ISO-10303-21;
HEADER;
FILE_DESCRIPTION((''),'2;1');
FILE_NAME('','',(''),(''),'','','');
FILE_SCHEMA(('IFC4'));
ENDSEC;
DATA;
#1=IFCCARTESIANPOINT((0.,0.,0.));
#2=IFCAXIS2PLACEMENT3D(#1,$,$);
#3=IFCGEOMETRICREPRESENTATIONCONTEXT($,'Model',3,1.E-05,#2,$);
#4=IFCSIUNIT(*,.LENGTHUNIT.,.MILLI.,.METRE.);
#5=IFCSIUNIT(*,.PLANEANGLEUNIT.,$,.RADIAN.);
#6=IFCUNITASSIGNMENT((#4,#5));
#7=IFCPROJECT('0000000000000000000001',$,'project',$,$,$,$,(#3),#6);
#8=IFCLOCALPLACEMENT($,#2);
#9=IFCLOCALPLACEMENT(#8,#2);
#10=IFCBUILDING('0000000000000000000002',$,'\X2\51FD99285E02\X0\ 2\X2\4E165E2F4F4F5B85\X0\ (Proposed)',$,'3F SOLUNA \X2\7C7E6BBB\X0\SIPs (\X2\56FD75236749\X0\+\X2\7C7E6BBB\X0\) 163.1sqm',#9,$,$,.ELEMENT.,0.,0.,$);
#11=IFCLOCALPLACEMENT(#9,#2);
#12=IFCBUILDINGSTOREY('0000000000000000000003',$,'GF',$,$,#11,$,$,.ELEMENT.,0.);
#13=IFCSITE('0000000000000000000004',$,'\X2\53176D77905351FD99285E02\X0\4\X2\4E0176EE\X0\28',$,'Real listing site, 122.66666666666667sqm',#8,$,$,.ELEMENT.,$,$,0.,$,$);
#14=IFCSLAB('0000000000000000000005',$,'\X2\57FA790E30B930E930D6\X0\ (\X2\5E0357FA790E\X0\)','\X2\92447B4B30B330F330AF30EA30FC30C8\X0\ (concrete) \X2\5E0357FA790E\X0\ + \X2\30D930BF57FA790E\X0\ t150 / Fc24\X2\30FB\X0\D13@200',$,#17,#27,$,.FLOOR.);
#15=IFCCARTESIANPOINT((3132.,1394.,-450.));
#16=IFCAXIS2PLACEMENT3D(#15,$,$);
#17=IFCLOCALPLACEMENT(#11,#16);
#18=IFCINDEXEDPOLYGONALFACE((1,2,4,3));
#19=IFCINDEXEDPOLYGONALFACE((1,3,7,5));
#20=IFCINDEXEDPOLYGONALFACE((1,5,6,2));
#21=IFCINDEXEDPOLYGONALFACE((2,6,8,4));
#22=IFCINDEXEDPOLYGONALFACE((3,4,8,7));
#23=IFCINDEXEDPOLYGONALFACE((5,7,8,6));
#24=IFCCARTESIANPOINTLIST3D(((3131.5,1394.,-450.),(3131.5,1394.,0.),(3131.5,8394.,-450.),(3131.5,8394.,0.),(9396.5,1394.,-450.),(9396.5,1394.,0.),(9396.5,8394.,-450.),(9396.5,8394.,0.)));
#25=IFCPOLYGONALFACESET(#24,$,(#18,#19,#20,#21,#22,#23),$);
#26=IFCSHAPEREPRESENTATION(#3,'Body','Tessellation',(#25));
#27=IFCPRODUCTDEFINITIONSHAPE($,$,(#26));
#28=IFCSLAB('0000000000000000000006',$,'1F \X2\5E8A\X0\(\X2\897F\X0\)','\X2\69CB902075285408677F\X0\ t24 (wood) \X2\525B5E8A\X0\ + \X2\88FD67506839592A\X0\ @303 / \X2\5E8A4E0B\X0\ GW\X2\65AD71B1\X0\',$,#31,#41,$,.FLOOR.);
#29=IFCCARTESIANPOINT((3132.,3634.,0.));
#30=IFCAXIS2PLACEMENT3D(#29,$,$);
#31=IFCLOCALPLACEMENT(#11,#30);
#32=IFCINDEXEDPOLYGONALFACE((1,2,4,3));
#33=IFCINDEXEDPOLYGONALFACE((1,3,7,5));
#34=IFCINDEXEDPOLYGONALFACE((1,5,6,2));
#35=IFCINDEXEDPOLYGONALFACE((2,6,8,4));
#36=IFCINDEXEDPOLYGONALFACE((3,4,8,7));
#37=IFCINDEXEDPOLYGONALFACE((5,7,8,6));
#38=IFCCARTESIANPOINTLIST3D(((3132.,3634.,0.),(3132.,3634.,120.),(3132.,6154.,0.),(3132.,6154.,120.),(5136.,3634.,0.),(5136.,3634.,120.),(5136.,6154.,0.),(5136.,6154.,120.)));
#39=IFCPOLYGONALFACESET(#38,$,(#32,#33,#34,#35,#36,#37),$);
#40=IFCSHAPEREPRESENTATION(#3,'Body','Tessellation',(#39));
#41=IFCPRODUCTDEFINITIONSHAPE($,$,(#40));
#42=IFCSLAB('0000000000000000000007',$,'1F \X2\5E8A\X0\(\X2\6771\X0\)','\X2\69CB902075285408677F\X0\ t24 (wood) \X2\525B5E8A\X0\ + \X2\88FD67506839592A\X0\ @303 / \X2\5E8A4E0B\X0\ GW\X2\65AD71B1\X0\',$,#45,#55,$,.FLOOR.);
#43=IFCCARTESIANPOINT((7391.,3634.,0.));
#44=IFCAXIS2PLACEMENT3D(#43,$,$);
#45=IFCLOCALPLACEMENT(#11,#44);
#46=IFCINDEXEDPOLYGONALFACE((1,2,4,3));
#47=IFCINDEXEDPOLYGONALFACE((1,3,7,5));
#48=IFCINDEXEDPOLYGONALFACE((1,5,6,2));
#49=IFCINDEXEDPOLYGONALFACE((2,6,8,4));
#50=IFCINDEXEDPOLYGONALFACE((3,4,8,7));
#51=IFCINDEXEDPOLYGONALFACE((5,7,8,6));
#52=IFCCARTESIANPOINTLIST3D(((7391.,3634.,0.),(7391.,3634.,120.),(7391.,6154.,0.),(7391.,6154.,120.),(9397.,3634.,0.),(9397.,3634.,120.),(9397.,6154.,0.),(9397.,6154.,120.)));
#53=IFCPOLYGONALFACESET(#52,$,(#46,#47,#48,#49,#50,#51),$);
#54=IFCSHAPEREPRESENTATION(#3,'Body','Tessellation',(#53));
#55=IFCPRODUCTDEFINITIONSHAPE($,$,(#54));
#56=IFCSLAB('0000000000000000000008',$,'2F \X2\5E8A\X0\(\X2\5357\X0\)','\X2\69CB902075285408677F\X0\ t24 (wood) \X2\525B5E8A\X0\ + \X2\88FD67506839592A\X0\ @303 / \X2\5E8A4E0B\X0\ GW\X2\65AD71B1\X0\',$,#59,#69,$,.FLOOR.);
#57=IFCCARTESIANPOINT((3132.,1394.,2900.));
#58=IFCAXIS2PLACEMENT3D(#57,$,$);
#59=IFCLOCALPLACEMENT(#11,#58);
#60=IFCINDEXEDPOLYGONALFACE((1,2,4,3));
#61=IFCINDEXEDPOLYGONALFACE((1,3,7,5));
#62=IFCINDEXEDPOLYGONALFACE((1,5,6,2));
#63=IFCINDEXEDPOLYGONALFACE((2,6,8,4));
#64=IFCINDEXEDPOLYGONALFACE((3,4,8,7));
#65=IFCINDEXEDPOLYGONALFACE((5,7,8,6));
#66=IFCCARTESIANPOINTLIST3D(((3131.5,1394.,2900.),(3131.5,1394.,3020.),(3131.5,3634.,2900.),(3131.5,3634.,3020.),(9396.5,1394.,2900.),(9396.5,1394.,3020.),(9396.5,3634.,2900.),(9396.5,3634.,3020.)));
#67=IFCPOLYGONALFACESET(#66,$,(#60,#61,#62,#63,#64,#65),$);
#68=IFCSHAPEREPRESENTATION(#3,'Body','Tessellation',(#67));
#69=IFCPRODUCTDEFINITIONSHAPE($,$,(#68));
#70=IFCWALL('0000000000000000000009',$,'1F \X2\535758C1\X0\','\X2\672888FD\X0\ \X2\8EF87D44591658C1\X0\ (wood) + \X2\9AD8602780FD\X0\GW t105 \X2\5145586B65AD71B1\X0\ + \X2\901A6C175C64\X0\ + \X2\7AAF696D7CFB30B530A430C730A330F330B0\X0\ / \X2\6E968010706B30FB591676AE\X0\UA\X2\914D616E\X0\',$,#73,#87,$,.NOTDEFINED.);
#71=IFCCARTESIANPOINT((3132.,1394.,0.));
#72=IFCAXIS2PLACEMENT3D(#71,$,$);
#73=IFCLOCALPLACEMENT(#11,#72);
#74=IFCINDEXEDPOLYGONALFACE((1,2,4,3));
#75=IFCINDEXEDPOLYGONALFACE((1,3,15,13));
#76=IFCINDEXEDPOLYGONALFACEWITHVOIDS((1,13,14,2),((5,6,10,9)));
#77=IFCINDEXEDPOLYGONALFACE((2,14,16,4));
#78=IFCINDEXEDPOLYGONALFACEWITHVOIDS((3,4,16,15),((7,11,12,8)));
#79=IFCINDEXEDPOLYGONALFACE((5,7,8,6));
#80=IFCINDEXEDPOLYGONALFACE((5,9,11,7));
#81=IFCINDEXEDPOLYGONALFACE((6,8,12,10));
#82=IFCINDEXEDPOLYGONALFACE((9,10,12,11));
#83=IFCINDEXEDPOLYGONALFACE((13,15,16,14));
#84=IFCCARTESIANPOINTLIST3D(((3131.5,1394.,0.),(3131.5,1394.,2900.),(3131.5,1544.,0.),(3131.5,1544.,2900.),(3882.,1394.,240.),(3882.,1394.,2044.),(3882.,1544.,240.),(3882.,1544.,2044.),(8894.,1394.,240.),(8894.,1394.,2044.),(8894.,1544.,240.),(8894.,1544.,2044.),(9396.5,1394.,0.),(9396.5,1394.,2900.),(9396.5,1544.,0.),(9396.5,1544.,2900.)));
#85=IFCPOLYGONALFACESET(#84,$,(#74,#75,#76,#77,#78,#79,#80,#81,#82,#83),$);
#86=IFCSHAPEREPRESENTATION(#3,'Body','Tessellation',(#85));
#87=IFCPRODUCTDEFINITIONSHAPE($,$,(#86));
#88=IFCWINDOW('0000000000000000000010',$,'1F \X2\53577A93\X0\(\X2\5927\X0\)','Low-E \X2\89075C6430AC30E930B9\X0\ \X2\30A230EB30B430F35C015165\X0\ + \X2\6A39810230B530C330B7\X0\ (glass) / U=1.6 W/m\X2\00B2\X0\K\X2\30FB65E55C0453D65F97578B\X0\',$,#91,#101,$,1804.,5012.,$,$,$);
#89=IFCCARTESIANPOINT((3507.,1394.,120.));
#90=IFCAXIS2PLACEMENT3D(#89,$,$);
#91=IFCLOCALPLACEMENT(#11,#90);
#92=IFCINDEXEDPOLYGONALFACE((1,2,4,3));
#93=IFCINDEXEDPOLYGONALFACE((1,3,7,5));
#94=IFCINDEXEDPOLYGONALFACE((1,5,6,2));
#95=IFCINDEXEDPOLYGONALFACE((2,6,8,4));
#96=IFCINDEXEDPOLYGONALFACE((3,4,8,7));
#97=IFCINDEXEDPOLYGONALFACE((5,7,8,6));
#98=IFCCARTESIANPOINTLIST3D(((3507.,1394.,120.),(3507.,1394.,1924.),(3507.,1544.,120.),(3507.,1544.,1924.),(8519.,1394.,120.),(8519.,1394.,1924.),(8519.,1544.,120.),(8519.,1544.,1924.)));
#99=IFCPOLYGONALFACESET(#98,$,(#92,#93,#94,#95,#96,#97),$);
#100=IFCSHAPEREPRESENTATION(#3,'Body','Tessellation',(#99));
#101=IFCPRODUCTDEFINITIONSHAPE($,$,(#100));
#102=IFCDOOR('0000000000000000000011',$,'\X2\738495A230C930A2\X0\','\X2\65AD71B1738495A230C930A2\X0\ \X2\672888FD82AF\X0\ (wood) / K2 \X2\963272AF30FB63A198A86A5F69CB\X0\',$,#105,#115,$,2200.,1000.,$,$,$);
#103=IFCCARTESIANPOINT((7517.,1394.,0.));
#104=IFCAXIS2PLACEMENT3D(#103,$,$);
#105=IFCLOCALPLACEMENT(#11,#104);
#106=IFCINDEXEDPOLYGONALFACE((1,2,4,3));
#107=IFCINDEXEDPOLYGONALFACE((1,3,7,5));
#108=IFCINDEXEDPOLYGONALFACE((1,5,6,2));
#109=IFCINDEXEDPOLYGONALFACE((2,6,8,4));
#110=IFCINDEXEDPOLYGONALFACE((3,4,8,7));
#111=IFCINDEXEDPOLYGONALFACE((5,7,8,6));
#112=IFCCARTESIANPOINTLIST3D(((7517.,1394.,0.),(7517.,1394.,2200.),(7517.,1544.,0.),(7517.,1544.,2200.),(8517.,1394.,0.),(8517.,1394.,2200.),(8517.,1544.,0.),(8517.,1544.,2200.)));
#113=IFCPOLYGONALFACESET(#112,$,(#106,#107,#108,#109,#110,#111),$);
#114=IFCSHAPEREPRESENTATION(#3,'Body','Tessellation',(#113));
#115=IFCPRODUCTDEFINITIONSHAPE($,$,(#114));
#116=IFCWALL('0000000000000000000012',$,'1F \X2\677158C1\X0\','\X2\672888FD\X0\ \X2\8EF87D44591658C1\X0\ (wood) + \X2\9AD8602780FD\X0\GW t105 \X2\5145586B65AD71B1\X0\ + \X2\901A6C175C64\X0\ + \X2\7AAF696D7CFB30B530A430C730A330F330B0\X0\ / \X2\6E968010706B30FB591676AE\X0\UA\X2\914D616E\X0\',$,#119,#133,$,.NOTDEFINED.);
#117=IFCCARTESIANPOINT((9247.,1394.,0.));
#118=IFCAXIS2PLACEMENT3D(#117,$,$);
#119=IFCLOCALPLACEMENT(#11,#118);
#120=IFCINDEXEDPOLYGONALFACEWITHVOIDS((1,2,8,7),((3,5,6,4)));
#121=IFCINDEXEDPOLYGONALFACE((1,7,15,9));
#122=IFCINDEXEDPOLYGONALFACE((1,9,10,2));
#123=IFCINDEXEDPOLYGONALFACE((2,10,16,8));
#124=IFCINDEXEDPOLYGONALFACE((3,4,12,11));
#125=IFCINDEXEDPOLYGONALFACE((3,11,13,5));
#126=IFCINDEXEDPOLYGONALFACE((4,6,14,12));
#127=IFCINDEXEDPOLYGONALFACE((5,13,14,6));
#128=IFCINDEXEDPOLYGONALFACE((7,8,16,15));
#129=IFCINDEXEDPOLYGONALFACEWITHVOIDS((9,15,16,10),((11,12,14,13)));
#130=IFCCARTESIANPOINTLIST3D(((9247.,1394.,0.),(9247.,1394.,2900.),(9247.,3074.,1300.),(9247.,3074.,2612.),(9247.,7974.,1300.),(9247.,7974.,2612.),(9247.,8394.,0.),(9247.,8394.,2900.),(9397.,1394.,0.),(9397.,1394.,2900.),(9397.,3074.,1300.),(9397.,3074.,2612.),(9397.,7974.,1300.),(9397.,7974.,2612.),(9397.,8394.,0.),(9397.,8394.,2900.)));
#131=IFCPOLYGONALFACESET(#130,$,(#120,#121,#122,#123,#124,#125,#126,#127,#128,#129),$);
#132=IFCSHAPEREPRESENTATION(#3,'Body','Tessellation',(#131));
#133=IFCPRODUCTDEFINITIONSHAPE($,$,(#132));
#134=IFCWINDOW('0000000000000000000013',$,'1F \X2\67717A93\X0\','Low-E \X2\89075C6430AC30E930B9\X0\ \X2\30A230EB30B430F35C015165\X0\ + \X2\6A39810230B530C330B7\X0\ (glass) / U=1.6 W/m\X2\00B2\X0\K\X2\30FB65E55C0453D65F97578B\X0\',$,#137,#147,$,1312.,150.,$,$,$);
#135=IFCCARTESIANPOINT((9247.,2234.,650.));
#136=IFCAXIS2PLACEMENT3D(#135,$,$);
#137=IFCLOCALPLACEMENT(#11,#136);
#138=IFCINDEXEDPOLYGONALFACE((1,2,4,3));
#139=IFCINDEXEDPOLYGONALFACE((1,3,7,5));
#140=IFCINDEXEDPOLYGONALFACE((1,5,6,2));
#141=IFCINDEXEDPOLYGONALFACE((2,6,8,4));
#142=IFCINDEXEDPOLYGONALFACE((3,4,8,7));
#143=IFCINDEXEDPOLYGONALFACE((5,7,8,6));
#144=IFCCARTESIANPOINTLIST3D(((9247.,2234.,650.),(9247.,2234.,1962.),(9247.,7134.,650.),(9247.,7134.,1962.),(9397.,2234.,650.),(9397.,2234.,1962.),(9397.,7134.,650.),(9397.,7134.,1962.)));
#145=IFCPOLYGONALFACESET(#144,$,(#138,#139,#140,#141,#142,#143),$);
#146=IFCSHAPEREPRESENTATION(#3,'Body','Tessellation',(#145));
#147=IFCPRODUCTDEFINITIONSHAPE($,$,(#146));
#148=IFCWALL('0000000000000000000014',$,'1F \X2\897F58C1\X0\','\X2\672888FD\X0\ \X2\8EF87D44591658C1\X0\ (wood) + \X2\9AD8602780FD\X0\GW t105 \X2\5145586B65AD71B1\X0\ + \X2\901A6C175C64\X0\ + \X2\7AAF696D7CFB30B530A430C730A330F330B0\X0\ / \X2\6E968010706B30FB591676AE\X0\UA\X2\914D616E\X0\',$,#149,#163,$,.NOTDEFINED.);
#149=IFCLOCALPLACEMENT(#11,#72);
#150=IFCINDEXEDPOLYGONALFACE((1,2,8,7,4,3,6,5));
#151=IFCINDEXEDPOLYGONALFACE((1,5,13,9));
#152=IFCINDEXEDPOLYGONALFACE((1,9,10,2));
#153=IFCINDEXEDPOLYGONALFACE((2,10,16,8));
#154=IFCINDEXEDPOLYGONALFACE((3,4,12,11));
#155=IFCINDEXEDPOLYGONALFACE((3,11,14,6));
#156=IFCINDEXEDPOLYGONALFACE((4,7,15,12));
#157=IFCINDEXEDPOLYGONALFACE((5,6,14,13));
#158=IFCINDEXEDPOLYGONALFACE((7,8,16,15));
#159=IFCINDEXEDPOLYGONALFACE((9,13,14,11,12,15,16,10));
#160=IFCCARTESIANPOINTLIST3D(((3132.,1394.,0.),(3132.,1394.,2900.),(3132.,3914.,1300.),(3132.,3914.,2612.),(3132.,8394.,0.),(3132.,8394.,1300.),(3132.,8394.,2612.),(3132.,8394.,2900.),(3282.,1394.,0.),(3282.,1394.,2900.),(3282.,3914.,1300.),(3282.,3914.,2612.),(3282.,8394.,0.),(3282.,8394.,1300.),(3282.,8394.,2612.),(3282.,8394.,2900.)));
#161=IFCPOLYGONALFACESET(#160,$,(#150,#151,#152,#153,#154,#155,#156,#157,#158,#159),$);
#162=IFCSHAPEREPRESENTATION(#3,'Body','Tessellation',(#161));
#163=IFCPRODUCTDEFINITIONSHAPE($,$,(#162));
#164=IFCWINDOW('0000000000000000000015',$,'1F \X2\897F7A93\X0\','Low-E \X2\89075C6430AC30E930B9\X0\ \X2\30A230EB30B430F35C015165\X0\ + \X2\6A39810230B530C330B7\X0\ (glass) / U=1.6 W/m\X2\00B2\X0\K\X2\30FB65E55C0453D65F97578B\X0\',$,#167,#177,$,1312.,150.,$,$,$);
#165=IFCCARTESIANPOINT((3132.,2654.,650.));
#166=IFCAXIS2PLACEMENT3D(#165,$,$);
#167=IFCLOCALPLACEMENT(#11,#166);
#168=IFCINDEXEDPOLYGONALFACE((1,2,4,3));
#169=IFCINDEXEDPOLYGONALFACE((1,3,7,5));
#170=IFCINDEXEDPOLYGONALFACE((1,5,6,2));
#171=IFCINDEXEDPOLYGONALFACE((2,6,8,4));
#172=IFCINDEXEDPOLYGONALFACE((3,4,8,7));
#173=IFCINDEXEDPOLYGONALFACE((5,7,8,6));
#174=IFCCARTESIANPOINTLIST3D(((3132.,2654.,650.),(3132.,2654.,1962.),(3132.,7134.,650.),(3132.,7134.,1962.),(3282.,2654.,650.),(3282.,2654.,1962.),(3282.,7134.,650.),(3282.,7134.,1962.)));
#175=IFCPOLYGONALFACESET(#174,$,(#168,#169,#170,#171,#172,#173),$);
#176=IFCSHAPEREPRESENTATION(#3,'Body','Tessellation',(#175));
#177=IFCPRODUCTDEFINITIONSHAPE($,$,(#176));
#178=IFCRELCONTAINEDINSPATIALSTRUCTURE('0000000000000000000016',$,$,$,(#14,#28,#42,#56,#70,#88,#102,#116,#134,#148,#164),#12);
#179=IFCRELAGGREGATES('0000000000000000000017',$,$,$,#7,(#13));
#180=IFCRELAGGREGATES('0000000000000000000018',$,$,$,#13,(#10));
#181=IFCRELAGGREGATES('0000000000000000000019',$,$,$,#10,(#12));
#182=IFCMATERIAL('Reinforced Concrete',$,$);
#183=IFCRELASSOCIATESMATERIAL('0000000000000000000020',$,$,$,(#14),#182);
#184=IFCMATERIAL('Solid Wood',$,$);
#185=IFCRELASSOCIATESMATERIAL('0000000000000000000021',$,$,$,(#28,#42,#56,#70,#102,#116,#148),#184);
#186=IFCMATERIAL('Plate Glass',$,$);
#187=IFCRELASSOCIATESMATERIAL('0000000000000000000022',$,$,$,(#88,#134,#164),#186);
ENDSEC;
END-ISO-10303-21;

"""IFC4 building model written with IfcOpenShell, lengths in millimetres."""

from ifc_helpers import new_model, si_unit, frame, frame_2d, origin, place, context, project, spatial, rectangle, extrude, material, element, fill, save


model = new_model("IFC4")

# Units and contexts
model_context = context("Model", 3, precision=1e-05, world=origin())
ifc_project = project(units=[si_unit("LENGTHUNIT", "METRE", prefix="MILLI"), si_unit("PLANEANGLEUNIT", "RADIAN")], contexts=[model_context])

# Site, building, storey
site_placement = place(None, origin())
site = spatial("IfcSite", under=ifc_project, at=site_placement, Name="北海道函館市4丁目28", ObjectType="Real listing site, 122.66666666666667sqm", CompositionType="ELEMENT", RefElevation=0.0)
building_placement = place(site_placement, origin())
building = spatial("IfcBuilding", under=site, at=building_placement, Name="函館市 2世帯住宅 (Proposed)", ObjectType="3F SOLUNA 籾殻SIPs (国産杉+籾殻) 163.1sqm", CompositionType="ELEMENT", ElevationOfRefHeight=0.0, ElevationOfTerrain=0.0)
storey_placement = place(building_placement, origin())
storey = spatial("IfcBuildingStorey", under=building, at=storey_placement, Name="GF", CompositionType="ELEMENT", Elevation=0.0)

# Slabs
ifc_material_1 = material(Name="Reinforced Concrete")
slab_1_placement = place(storey_placement, frame((3132.0, 1394.0, -450.0)))
element("IfcSlab", 1, at=slab_1_placement, inside=storey, material=ifc_material_1, Name="基礎スラブ (布基礎)", Description="鉄筋コンクリート (concrete) 布基礎 + ベタ基礎 t150 / Fc24・D13@200", PredefinedType="FLOOR", context=model_context, shape_type="SweptSolid", body=[
    extrude(rectangle(XDim=6265.0, YDim=7000.0, at=frame_2d((3132.0, 3500.0))), frame((3132.0, 1394.0, -450.0)), (0.0, 0.0, 1.0), 450.0),
])
ifc_material_2 = material(Name="Solid Wood")
slab_2_placement = place(storey_placement, frame((3132.0, 3634.0, 0.0)))
element("IfcSlab", 2, at=slab_2_placement, inside=storey, material=ifc_material_2, Name="1F 床(西)", Description="構造用合板 t24 (wood) 剛床 + 製材根太 @303 / 床下 GW断熱", PredefinedType="FLOOR", context=model_context, shape_type="SweptSolid", body=[
    extrude(rectangle(XDim=2004.0, YDim=2520.0, at=frame_2d((1002.0, 1260.0))), frame((3132.0, 3634.0, 0.0)), (0.0, 0.0, 1.0), 120.0),
])
slab_3_placement = place(storey_placement, frame((7391.0, 3634.0, 0.0)))
element("IfcSlab", 3, at=slab_3_placement, inside=storey, material=ifc_material_2, Name="1F 床(東)", Description="構造用合板 t24 (wood) 剛床 + 製材根太 @303 / 床下 GW断熱", PredefinedType="FLOOR", context=model_context, shape_type="SweptSolid", body=[
    extrude(rectangle(XDim=2006.0, YDim=2520.0, at=frame_2d((1003.0, 1260.0))), frame((7391.0, 3634.0, 0.0)), (0.0, 0.0, 1.0), 120.0),
])
slab_4_placement = place(storey_placement, frame((3132.0, 1394.0, 2900.0)))
element("IfcSlab", 4, at=slab_4_placement, inside=storey, material=ifc_material_2, Name="2F 床(南)", Description="構造用合板 t24 (wood) 剛床 + 製材根太 @303 / 床下 GW断熱", PredefinedType="FLOOR", context=model_context, shape_type="SweptSolid", body=[
    extrude(rectangle(XDim=6265.0, YDim=2240.0, at=frame_2d((3132.0, 1120.0))), frame((3132.0, 1394.0, 2900.0)), (0.0, 0.0, 1.0), 120.0),
])

# Wall, openings, window, door
wall_1_placement = place(storey_placement, frame((3132.0, 1394.0, 0.0)))
wall_1 = element("IfcWall", 5, at=wall_1_placement, inside=storey, material=ifc_material_2, Name="1F 南壁", Description="木製 軸組外壁 (wood) + 高性能GW t105 充填断熱 + 通気層 + 窯業系サイディング / 準耐火・外皮UA配慮", PredefinedType="NOTDEFINED", context=model_context, shape_type="SweptSolid", body=[
    extrude(rectangle(XDim=6265.0, YDim=150.0, at=frame_2d((3132.0, 75.0))), frame((3132.0, 1394.0, 0.0)), (0.0, 0.0, 1.0), 2900.0),
])
opening_1_placement = place(storey_placement, frame((3507.0, 1394.0, 120.0)))
opening_1 = element("IfcOpeningElement", 6, at=opening_1_placement, cuts=wall_1, PredefinedType="NOTDEFINED", context=model_context, shape_type="SweptSolid", body=[
    extrude(rectangle(XDim=5012.0, YDim=150.0, at=frame_2d((2506.0, 75.0))), frame((3507.0, 1394.0, 120.0)), (0.0, 0.0, 1.0), 1804.0),
])
opening_2_placement = place(storey_placement, frame((7517.0, 1394.0, 0.0)))
opening_2 = element("IfcOpeningElement", 7, at=opening_2_placement, cuts=wall_1, PredefinedType="NOTDEFINED", context=model_context, shape_type="SweptSolid", body=[
    extrude(rectangle(XDim=1000.0, YDim=150.0, at=frame_2d((500.0, 75.0))), frame((7517.0, 1394.0, 0.0)), (0.0, 0.0, 1.0), 2200.0),
])
ifc_material_3 = material(Name="Plate Glass")
window_1_placement = place(storey_placement, frame((3507.0, 1394.0, 120.0)))
window_1 = element("IfcWindow", 8, at=window_1_placement, inside=storey, material=ifc_material_3, Name="1F 南窓(大)", Description="Low-E 複層ガラス アルゴン封入 + 樹脂サッシ (glass) / U=1.6 W/m²K・日射取得型", OverallHeight=1804.0, OverallWidth=5012.0, context=model_context, shape_type="SweptSolid", body=[
    extrude(rectangle(XDim=5012.0, YDim=150.0, at=frame_2d((2506.0, 75.0))), frame((3507.0, 1394.0, 120.0)), (0.0, 0.0, 1.0), 1804.0),
])
fill(opening_1, window_1)
door_placement = place(storey_placement, frame((7517.0, 1394.0, 0.0)))
door = element("IfcDoor", 9, at=door_placement, inside=storey, material=ifc_material_2, Name="玄関ドア", Description="断熱玄関ドア 木製芯 (wood) / K2 防犯・採風機構", OverallHeight=2200.0, OverallWidth=1000.0, context=model_context, shape_type="SweptSolid", body=[
    extrude(rectangle(XDim=1000.0, YDim=150.0, at=frame_2d((500.0, 75.0))), frame((7517.0, 1394.0, 0.0)), (0.0, 0.0, 1.0), 2200.0),
])
fill(opening_2, door)

# Walls, openings, windows
wall_2_placement = place(storey_placement, frame((9247.0, 1394.0, 0.0)))
wall_2 = element("IfcWall", 10, at=wall_2_placement, inside=storey, material=ifc_material_2, Name="1F 東壁", Description="木製 軸組外壁 (wood) + 高性能GW t105 充填断熱 + 通気層 + 窯業系サイディング / 準耐火・外皮UA配慮", PredefinedType="NOTDEFINED", context=model_context, shape_type="SweptSolid", body=[
    extrude(rectangle(XDim=150.0, YDim=7000.0, at=frame_2d((75.0, 3500.0))), frame((9247.0, 1394.0, 0.0)), (0.0, 0.0, 1.0), 2900.0),
])
opening_3_placement = place(storey_placement, frame((9247.0, 2234.0, 650.0)))
opening_3 = element("IfcOpeningElement", 11, at=opening_3_placement, cuts=wall_2, PredefinedType="NOTDEFINED", context=model_context, shape_type="SweptSolid", body=[
    extrude(rectangle(XDim=150.0, YDim=4900.0, at=frame_2d((75.0, 2450.0))), frame((9247.0, 2234.0, 650.0)), (0.0, 0.0, 1.0), 1312.0),
])
window_2_placement = place(storey_placement, frame((9247.0, 2234.0, 650.0)))
window_2 = element("IfcWindow", 12, at=window_2_placement, inside=storey, material=ifc_material_3, Name="1F 東窓", Description="Low-E 複層ガラス アルゴン封入 + 樹脂サッシ (glass) / U=1.6 W/m²K・日射取得型", OverallHeight=1312.0, OverallWidth=150.0, context=model_context, shape_type="SweptSolid", body=[
    extrude(rectangle(XDim=150.0, YDim=4900.0, at=frame_2d((75.0, 2450.0))), frame((9247.0, 2234.0, 650.0)), (0.0, 0.0, 1.0), 1312.0),
])
fill(opening_3, window_2)
wall_3_placement = place(storey_placement, frame((3132.0, 1394.0, 0.0)))
wall_3 = element("IfcWall", 13, at=wall_3_placement, inside=storey, material=ifc_material_2, Name="1F 西壁", Description="木製 軸組外壁 (wood) + 高性能GW t105 充填断熱 + 通気層 + 窯業系サイディング / 準耐火・外皮UA配慮", PredefinedType="NOTDEFINED", context=model_context, shape_type="SweptSolid", body=[
    extrude(rectangle(XDim=150.0, YDim=7000.0, at=frame_2d((75.0, 3500.0))), frame((3132.0, 1394.0, 0.0)), (0.0, 0.0, 1.0), 2900.0),
])
opening_4_placement = place(storey_placement, frame((3132.0, 2654.0, 650.0)))
opening_4 = element("IfcOpeningElement", 14, at=opening_4_placement, cuts=wall_3, PredefinedType="NOTDEFINED", context=model_context, shape_type="SweptSolid", body=[
    extrude(rectangle(XDim=150.0, YDim=4480.0, at=frame_2d((75.0, 2240.0))), frame((3132.0, 2654.0, 650.0)), (0.0, 0.0, 1.0), 1312.0),
])
window_3_placement = place(storey_placement, frame((3132.0, 2654.0, 650.0)))
window_3 = element("IfcWindow", 15, at=window_3_placement, inside=storey, material=ifc_material_3, Name="1F 西窓", Description="Low-E 複層ガラス アルゴン封入 + 樹脂サッシ (glass) / U=1.6 W/m²K・日射取得型", OverallHeight=1312.0, OverallWidth=150.0, context=model_context, shape_type="SweptSolid", body=[
    extrude(rectangle(XDim=150.0, YDim=4480.0, at=frame_2d((75.0, 2240.0))), frame((3132.0, 2654.0, 650.0)), (0.0, 0.0, 1.0), 1312.0),
])
fill(opening_4, window_3)

save(model, "model.ifc")
